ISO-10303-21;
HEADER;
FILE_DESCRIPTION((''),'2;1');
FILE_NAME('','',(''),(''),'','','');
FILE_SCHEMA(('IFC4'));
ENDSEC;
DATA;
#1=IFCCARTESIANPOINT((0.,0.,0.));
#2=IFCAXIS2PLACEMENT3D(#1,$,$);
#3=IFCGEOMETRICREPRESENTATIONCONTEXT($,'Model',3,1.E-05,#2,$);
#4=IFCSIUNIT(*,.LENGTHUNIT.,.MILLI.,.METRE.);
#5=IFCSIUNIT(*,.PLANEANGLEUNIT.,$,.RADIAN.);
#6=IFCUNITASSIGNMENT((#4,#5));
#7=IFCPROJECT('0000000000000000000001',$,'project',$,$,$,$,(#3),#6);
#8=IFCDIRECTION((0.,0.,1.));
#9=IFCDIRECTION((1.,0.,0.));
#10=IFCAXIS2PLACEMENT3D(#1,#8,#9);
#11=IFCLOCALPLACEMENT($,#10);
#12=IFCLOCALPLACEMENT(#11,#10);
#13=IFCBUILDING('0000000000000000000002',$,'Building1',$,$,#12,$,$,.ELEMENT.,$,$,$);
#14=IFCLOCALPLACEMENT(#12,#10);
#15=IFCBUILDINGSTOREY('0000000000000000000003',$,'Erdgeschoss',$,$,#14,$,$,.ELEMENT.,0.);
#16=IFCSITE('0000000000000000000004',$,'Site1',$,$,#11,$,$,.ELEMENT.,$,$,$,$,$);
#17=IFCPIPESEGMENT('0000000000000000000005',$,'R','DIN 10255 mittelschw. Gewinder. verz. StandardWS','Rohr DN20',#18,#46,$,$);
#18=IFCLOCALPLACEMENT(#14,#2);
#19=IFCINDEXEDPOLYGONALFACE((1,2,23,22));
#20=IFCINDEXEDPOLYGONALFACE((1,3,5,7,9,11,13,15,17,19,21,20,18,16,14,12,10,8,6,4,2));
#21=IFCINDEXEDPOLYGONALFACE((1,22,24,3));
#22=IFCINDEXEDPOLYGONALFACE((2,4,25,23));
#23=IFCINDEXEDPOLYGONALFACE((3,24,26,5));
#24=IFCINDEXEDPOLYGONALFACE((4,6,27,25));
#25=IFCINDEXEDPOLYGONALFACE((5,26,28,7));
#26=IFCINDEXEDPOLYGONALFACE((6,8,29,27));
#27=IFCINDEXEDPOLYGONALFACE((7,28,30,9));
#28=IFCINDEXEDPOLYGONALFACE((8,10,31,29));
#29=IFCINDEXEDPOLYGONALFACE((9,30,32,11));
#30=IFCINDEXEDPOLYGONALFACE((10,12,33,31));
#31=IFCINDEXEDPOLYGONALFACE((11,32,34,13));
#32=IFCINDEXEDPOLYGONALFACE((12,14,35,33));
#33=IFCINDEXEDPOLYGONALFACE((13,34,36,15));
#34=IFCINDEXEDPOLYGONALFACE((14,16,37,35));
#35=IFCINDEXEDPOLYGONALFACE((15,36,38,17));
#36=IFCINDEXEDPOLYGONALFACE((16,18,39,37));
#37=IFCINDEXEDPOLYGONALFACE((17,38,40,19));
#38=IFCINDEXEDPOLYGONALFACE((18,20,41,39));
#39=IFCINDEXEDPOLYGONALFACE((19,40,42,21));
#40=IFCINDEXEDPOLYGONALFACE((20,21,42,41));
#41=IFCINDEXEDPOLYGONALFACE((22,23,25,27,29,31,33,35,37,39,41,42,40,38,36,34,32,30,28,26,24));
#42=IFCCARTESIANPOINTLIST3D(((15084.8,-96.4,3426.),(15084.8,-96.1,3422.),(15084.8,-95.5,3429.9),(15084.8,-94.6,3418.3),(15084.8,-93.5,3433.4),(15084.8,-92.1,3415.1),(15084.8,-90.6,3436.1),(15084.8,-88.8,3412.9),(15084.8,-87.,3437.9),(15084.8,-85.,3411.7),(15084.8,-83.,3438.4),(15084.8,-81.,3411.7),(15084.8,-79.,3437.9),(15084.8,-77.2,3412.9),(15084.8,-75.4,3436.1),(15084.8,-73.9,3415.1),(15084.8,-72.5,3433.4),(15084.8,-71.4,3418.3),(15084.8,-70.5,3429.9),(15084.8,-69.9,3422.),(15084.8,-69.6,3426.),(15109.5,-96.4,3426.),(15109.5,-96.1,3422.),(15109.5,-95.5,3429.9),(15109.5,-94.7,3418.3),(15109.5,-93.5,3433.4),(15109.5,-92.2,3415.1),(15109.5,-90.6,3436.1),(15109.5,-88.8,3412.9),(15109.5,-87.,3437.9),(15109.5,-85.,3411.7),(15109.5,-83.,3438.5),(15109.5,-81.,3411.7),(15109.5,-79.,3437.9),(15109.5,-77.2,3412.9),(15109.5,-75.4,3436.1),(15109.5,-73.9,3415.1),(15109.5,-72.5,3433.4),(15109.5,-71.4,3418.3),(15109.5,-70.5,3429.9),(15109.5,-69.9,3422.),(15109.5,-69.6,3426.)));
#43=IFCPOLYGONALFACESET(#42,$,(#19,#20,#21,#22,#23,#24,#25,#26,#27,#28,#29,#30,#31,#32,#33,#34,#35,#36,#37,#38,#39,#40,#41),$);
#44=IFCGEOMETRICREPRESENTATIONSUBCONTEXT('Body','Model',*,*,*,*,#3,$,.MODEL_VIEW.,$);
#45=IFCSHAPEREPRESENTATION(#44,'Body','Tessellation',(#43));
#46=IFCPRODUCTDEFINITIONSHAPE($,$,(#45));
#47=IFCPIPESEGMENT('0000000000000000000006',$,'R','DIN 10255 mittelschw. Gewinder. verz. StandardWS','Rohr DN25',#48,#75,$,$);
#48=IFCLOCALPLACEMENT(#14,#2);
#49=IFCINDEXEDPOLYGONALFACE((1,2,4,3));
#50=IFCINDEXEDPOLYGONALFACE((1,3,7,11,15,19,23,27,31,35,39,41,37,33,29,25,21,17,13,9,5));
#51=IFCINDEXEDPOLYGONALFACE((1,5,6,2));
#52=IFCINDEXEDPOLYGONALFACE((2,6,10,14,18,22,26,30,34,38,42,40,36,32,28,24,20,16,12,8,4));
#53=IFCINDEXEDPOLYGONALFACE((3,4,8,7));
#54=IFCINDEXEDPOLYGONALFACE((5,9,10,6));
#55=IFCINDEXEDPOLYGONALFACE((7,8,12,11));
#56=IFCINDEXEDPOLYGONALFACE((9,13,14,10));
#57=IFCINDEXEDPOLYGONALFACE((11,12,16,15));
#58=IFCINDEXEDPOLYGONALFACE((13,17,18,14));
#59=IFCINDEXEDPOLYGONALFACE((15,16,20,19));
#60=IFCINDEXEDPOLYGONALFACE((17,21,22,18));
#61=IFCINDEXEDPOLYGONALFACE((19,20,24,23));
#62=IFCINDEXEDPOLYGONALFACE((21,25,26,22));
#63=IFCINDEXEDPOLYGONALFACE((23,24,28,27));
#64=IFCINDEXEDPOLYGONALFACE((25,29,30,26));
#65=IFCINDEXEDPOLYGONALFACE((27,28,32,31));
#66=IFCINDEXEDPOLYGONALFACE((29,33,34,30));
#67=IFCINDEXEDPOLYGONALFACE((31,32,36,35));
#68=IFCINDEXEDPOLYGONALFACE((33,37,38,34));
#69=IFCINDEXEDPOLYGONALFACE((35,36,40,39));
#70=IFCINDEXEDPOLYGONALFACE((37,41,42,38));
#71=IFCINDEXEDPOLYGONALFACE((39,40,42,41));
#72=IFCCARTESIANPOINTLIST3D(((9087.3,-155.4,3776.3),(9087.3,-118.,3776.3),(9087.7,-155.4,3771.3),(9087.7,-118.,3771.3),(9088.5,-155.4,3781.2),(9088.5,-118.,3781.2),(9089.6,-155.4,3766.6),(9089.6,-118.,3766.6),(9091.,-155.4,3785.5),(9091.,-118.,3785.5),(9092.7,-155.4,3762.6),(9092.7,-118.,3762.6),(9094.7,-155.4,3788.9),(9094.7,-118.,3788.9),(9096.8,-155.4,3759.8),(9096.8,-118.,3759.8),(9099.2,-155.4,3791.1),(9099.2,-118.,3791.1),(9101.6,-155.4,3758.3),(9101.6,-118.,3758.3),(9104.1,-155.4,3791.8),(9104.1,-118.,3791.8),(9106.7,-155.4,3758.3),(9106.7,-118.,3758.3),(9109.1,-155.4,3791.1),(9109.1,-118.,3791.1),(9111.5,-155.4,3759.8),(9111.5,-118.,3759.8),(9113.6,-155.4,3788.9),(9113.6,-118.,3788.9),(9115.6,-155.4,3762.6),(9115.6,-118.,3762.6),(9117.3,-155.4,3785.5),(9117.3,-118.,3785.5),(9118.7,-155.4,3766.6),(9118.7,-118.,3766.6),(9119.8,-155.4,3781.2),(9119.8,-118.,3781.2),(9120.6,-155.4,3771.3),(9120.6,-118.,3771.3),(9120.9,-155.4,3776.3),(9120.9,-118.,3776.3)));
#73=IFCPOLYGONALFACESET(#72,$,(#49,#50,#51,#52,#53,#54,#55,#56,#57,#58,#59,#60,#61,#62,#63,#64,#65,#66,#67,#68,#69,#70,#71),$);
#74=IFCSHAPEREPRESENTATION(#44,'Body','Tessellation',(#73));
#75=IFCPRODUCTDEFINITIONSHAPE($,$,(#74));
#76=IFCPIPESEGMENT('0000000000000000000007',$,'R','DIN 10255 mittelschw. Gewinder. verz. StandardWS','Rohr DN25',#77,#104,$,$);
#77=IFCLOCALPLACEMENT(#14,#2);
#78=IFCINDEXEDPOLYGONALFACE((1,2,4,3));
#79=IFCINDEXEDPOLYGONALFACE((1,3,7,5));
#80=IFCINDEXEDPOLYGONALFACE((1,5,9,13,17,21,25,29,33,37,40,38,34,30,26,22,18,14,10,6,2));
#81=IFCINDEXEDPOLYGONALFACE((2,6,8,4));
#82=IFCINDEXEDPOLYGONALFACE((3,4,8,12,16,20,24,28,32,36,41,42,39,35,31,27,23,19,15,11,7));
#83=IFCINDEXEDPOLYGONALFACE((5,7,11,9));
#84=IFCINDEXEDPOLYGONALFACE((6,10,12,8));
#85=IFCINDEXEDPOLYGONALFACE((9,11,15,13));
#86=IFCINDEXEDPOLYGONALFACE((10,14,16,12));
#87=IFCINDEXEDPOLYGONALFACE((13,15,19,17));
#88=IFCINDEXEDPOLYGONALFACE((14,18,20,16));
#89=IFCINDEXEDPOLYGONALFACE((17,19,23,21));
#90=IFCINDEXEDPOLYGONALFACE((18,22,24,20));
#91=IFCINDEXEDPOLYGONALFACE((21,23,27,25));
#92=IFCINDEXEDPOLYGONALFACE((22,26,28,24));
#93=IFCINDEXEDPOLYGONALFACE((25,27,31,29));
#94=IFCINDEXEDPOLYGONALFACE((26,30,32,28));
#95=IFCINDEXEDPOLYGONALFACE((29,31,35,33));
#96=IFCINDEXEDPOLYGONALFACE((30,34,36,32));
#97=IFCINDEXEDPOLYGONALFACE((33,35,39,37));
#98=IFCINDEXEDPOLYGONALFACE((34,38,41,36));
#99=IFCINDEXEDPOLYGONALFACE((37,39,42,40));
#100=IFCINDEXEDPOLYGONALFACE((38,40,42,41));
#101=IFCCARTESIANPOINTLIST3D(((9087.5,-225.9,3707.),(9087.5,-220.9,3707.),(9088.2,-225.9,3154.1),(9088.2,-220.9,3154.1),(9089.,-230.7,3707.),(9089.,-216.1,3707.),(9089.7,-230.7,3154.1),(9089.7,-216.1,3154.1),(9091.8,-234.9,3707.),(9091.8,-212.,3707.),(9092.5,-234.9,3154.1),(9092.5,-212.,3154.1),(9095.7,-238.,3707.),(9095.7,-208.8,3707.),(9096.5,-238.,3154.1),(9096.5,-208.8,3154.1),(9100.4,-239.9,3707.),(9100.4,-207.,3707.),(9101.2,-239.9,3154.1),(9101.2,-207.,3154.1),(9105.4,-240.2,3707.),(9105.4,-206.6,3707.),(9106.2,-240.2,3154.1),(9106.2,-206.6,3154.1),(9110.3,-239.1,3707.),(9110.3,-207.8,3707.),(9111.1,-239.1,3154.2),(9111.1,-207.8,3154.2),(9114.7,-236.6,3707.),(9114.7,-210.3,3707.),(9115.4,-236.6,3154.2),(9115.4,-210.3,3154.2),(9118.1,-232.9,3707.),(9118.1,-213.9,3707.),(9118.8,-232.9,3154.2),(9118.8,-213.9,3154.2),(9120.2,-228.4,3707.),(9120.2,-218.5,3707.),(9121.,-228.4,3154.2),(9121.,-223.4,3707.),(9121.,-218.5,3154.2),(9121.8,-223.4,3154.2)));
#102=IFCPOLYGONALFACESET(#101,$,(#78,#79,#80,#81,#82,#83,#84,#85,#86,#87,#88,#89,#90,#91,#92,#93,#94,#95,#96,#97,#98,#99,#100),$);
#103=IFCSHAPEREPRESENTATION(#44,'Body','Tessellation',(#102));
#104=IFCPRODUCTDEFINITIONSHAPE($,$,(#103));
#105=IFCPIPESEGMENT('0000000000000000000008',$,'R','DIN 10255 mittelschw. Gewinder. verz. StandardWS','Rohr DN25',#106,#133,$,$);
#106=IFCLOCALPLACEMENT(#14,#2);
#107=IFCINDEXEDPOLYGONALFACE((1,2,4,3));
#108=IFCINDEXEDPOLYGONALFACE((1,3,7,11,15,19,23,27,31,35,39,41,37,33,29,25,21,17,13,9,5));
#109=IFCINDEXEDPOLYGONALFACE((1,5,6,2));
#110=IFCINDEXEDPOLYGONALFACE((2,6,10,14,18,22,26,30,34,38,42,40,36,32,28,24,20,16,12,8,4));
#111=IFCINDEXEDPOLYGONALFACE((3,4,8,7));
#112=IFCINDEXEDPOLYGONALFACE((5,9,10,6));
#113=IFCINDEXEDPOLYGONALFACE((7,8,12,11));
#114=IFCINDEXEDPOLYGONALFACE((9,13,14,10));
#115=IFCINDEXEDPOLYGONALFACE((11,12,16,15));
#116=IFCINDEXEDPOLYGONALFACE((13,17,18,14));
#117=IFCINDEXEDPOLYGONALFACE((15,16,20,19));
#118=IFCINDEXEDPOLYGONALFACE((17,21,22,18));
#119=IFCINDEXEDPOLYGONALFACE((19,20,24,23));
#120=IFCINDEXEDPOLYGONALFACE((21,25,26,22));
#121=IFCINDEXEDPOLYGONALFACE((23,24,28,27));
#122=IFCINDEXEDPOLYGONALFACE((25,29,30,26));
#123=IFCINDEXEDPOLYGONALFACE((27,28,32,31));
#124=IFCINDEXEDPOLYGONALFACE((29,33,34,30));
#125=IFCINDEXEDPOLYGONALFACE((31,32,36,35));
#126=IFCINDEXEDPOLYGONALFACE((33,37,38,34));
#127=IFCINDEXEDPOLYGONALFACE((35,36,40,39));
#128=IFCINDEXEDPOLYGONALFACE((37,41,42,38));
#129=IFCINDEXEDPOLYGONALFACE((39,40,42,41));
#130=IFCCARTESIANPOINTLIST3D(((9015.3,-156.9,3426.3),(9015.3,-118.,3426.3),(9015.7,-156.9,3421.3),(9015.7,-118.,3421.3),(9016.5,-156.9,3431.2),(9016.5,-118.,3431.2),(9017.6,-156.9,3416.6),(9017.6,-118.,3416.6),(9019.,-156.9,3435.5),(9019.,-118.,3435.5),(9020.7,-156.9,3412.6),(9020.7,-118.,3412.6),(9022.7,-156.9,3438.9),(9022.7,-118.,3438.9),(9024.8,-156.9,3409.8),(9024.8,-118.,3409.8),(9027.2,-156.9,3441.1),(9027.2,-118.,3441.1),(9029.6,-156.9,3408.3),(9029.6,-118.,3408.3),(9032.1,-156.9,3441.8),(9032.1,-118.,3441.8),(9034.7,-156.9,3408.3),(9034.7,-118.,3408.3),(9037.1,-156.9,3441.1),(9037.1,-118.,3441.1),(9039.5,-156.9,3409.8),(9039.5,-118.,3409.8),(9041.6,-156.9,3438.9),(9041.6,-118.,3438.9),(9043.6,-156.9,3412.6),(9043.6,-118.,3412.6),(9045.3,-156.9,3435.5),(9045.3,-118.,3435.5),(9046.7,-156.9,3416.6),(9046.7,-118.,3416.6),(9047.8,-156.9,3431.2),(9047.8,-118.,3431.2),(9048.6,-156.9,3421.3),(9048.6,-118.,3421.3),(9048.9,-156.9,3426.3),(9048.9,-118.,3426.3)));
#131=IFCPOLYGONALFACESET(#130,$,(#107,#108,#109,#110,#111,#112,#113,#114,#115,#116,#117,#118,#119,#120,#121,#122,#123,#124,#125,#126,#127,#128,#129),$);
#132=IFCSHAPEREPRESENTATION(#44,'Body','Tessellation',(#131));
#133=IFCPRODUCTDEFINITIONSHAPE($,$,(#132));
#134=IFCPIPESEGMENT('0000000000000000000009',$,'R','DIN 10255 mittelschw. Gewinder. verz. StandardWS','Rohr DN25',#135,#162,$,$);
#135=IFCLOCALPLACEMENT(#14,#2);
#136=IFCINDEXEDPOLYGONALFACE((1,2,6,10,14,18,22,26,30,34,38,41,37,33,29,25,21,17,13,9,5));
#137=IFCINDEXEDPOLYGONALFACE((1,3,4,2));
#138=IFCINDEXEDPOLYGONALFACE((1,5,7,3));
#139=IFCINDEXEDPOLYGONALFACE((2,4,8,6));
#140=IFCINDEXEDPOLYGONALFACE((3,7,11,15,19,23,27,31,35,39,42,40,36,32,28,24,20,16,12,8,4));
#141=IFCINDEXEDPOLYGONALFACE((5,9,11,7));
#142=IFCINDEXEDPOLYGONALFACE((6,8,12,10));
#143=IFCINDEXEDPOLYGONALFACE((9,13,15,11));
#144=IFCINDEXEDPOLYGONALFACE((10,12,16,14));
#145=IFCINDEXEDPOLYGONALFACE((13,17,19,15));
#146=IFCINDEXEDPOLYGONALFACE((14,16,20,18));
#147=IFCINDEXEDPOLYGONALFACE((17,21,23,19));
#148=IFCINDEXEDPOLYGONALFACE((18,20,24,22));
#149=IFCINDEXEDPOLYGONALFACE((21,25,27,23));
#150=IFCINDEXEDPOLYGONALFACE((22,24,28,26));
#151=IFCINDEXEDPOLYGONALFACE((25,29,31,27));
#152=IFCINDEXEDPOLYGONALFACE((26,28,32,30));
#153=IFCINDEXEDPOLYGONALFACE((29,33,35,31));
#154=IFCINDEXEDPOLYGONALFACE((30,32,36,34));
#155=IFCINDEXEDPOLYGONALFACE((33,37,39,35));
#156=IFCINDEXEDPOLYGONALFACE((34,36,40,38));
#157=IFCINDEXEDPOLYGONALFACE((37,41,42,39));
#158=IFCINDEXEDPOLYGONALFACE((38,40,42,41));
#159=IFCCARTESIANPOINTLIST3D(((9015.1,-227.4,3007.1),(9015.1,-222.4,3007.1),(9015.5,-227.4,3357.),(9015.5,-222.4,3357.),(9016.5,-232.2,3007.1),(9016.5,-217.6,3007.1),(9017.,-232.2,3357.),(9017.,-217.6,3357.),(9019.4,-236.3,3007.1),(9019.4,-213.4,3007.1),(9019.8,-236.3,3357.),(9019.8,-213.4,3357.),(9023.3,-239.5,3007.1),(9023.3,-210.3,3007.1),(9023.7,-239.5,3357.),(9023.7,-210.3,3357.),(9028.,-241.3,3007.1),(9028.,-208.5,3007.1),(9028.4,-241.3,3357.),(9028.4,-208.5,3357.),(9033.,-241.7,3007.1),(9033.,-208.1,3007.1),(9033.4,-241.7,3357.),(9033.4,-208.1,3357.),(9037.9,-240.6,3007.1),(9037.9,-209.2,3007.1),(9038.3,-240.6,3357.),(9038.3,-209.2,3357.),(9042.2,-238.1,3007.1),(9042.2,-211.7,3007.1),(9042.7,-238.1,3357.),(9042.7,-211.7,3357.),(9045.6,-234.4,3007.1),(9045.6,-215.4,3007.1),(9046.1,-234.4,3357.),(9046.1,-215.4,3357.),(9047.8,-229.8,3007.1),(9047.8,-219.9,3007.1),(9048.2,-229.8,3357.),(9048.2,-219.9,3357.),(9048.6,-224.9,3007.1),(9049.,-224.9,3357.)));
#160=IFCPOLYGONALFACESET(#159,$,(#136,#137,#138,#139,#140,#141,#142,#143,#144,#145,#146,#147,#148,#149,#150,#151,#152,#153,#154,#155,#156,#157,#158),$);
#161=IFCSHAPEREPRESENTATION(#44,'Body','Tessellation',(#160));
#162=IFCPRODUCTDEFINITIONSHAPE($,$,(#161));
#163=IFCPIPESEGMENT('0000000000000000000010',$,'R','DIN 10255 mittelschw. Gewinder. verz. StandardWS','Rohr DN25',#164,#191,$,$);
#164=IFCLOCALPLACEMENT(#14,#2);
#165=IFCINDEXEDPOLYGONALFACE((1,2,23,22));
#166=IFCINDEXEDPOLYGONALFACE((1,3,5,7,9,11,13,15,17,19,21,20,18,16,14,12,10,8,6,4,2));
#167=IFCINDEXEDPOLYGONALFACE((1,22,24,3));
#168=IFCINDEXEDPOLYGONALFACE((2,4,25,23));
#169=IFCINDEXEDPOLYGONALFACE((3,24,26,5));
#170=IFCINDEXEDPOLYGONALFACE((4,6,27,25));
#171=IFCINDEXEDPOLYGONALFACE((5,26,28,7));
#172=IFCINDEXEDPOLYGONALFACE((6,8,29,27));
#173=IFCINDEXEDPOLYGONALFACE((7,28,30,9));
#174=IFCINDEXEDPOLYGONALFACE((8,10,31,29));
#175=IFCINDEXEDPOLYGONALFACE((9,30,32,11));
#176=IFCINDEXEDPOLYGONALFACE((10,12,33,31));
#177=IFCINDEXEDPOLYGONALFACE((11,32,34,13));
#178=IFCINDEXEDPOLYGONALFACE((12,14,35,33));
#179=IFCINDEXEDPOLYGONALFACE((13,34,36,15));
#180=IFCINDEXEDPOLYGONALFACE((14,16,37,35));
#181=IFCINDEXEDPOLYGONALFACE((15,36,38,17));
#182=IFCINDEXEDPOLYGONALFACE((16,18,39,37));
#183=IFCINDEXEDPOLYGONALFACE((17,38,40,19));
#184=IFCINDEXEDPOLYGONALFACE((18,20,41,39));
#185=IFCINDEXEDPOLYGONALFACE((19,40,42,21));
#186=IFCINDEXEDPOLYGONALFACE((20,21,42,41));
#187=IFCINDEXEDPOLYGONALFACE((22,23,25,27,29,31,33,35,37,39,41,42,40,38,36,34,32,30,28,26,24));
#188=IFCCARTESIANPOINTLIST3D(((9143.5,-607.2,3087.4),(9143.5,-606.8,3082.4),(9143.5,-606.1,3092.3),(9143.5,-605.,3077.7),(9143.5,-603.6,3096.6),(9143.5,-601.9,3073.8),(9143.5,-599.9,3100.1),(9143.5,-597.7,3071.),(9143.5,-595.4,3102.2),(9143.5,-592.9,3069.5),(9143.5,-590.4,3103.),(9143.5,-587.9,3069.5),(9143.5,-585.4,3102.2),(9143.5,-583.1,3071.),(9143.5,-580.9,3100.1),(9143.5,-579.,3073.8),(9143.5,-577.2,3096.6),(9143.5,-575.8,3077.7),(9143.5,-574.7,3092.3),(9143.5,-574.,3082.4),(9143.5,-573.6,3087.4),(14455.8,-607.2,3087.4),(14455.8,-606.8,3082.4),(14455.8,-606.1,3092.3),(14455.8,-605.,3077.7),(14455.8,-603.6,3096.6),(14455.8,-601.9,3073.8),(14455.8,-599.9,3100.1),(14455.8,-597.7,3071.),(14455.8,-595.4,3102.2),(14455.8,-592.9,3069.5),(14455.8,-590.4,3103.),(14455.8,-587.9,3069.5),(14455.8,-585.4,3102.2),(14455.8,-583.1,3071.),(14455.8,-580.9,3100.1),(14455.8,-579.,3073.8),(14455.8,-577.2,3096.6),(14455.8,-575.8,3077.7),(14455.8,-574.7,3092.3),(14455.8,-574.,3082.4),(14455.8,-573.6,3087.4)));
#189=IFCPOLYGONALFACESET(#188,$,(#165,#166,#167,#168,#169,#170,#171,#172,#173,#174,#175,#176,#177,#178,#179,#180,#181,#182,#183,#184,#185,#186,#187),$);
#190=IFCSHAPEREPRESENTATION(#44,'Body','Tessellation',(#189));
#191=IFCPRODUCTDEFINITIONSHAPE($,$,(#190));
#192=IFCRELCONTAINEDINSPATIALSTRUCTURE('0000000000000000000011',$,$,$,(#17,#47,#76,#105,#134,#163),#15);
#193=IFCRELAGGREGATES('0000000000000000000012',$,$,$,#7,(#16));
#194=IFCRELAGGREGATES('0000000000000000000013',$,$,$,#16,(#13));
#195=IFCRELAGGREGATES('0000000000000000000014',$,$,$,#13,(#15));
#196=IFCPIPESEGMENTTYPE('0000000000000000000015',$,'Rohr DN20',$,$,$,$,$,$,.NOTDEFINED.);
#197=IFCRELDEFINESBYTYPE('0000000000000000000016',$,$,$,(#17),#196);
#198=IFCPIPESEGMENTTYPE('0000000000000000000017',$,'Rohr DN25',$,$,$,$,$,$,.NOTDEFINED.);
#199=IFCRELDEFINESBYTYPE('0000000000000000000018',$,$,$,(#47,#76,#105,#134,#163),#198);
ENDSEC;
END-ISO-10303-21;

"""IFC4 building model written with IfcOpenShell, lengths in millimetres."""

from ifc_helpers import new_model, si_unit, frame, origin, origin_with_axes, origin_2d_with_axis, place, context, subcontext, project, spatial, circle, extrude, type_object, element, save


model = new_model("IFC4")

# Units and contexts
model_context = context("Model", 3, precision=1e-05, world=origin())
body_context = subcontext(model_context, "Body", "Model", "MODEL_VIEW")
ifc_project = project(units=[si_unit("LENGTHUNIT", "METRE", prefix="MILLI"), si_unit("PLANEANGLEUNIT", "RADIAN")], contexts=[model_context])

# Site, building, storey
site_placement = place(None, origin_with_axes())
site = spatial("IfcSite", under=ifc_project, at=site_placement, Name="Site1", CompositionType="ELEMENT")
building_placement = place(site_placement, origin_with_axes())
building = spatial("IfcBuilding", under=site, at=building_placement, Name="Building1", CompositionType="ELEMENT")
storey_placement = place(building_placement, origin_with_axes())
storey = spatial("IfcBuildingStorey", under=building, at=storey_placement, Name="Erdgeschoss", CompositionType="ELEMENT", Elevation=0.0)

# Pipe segments
pipe_segment_type_1 = type_object("IfcPipeSegmentType", Name="Rohr DN20", PredefinedType="NOTDEFINED")
pipe_segment_1_placement = place(storey_placement, frame((15097.2, -83.2, 3425.0), z_axis=(0.0, 0.0, 1.0), x_axis=(1.0, 0.0, 0.0)))
element("IfcPipeSegment", 1, at=pipe_segment_1_placement, inside=storey, type_object=pipe_segment_type_1, Name="R", Description="DIN 10255 mittelschw. Gewinder. verz. StandardWS", ObjectType="Rohr DN20", context=body_context, shape_type="SolidModel", body=[
    extrude(circle(Radius=13.4, at=origin_2d_with_axis()), frame((12.3, 0.1, 0.0), z_axis=(-1.0, 0.000133, -0.000096), x_axis=(0.0, 0.0, 1.0)), (0.0, 0.0, 1.0), 24.7),
])
pipe_segment_type_2 = type_object("IfcPipeSegmentType", Name="Rohr DN25", PredefinedType="NOTDEFINED")
pipe_segment_2_placement = place(storey_placement, frame((9104.3, -136.7, 3775.0), z_axis=(0.0, 0.0, 1.0), x_axis=(1.0, 0.0, 0.0)))
element("IfcPipeSegment", 2, at=pipe_segment_2_placement, inside=storey, type_object=pipe_segment_type_2, Name="R", Description="DIN 10255 mittelschw. Gewinder. verz. StandardWS", ObjectType="Rohr DN25", context=body_context, shape_type="SolidModel", body=[
    extrude(circle(Radius=16.9, at=origin_2d_with_axis()), frame((-0.1, 18.7, 0.0), z_axis=(0.0, -1.0, 0.0), x_axis=(0.0, 0.0, 1.0)), (0.0, 0.0, 1.0), 37.4),
])
pipe_segment_3_placement = place(storey_placement, frame((9104.5, -223.3, 3430.6), z_axis=(0.0, 0.0, 1.0), x_axis=(1.0, 0.0, 0.0)))
element("IfcPipeSegment", 3, at=pipe_segment_3_placement, inside=storey, type_object=pipe_segment_type_2, Name="R", Description="DIN 10255 mittelschw. Gewinder. verz. StandardWS", ObjectType="Rohr DN25", context=body_context, shape_type="SolidModel", body=[
    extrude(circle(Radius=16.9, at=origin_2d_with_axis()), frame((-0.4, -0.2, 276.4), z_axis=(0.001364, 0.0, -0.999999), x_axis=(1.0, 0.0, 0.0)), (0.0, 0.0, 1.0), 552.9),
])
pipe_segment_4_placement = place(storey_placement, frame((9032.3, -137.4, 3425.0), z_axis=(0.0, 0.0, 1.0), x_axis=(1.0, 0.0, 0.0)))
element("IfcPipeSegment", 4, at=pipe_segment_4_placement, inside=storey, type_object=pipe_segment_type_2, Name="R", Description="DIN 10255 mittelschw. Gewinder. verz. StandardWS", ObjectType="Rohr DN25", context=body_context, shape_type="SolidModel", body=[
    extrude(circle(Radius=16.9, at=origin_2d_with_axis()), frame((-0.1, 19.4, 0.0), z_axis=(0.0, -1.0, 0.0), x_axis=(0.0, 0.0, 1.0)), (0.0, 0.0, 1.0), 38.9),
])
pipe_segment_5_placement = place(storey_placement, frame((9031.9, -225.0, 3182.1), z_axis=(0.0, 0.0, 1.0), x_axis=(1.0, 0.0, 0.0)))
element("IfcPipeSegment", 5, at=pipe_segment_5_placement, inside=storey, type_object=pipe_segment_type_2, Name="R", Description="DIN 10255 mittelschw. Gewinder. verz. StandardWS", ObjectType="Rohr DN25", context=body_context, shape_type="SolidModel", body=[
    extrude(circle(Radius=16.9, at=origin_2d_with_axis()), frame((0.2, 0.2, 174.9), z_axis=(-0.001207, 0.0, -0.999999), x_axis=(1.0, 0.0, 0.0)), (0.0, 0.0, 1.0), 349.9),
])
pipe_segment_6_placement = place(storey_placement, frame((11799.6, -590.3, 3086.1), z_axis=(0.0, 0.0, 1.0), x_axis=(1.0, 0.0, 0.0)))
element("IfcPipeSegment", 6, at=pipe_segment_6_placement, inside=storey, type_object=pipe_segment_type_2, Name="R", Description="DIN 10255 mittelschw. Gewinder. verz. StandardWS", ObjectType="Rohr DN25", context=body_context, shape_type="SolidModel", body=[
    extrude(circle(Radius=16.9, at=origin_2d_with_axis()), frame((-2656.1, -0.2, 0.0), z_axis=(1.0, 0.0, 0.0), x_axis=(0.0, 0.0, 1.0)), (0.0, 0.0, 1.0), 5312.3),
])

save(model, "model.ifc")
